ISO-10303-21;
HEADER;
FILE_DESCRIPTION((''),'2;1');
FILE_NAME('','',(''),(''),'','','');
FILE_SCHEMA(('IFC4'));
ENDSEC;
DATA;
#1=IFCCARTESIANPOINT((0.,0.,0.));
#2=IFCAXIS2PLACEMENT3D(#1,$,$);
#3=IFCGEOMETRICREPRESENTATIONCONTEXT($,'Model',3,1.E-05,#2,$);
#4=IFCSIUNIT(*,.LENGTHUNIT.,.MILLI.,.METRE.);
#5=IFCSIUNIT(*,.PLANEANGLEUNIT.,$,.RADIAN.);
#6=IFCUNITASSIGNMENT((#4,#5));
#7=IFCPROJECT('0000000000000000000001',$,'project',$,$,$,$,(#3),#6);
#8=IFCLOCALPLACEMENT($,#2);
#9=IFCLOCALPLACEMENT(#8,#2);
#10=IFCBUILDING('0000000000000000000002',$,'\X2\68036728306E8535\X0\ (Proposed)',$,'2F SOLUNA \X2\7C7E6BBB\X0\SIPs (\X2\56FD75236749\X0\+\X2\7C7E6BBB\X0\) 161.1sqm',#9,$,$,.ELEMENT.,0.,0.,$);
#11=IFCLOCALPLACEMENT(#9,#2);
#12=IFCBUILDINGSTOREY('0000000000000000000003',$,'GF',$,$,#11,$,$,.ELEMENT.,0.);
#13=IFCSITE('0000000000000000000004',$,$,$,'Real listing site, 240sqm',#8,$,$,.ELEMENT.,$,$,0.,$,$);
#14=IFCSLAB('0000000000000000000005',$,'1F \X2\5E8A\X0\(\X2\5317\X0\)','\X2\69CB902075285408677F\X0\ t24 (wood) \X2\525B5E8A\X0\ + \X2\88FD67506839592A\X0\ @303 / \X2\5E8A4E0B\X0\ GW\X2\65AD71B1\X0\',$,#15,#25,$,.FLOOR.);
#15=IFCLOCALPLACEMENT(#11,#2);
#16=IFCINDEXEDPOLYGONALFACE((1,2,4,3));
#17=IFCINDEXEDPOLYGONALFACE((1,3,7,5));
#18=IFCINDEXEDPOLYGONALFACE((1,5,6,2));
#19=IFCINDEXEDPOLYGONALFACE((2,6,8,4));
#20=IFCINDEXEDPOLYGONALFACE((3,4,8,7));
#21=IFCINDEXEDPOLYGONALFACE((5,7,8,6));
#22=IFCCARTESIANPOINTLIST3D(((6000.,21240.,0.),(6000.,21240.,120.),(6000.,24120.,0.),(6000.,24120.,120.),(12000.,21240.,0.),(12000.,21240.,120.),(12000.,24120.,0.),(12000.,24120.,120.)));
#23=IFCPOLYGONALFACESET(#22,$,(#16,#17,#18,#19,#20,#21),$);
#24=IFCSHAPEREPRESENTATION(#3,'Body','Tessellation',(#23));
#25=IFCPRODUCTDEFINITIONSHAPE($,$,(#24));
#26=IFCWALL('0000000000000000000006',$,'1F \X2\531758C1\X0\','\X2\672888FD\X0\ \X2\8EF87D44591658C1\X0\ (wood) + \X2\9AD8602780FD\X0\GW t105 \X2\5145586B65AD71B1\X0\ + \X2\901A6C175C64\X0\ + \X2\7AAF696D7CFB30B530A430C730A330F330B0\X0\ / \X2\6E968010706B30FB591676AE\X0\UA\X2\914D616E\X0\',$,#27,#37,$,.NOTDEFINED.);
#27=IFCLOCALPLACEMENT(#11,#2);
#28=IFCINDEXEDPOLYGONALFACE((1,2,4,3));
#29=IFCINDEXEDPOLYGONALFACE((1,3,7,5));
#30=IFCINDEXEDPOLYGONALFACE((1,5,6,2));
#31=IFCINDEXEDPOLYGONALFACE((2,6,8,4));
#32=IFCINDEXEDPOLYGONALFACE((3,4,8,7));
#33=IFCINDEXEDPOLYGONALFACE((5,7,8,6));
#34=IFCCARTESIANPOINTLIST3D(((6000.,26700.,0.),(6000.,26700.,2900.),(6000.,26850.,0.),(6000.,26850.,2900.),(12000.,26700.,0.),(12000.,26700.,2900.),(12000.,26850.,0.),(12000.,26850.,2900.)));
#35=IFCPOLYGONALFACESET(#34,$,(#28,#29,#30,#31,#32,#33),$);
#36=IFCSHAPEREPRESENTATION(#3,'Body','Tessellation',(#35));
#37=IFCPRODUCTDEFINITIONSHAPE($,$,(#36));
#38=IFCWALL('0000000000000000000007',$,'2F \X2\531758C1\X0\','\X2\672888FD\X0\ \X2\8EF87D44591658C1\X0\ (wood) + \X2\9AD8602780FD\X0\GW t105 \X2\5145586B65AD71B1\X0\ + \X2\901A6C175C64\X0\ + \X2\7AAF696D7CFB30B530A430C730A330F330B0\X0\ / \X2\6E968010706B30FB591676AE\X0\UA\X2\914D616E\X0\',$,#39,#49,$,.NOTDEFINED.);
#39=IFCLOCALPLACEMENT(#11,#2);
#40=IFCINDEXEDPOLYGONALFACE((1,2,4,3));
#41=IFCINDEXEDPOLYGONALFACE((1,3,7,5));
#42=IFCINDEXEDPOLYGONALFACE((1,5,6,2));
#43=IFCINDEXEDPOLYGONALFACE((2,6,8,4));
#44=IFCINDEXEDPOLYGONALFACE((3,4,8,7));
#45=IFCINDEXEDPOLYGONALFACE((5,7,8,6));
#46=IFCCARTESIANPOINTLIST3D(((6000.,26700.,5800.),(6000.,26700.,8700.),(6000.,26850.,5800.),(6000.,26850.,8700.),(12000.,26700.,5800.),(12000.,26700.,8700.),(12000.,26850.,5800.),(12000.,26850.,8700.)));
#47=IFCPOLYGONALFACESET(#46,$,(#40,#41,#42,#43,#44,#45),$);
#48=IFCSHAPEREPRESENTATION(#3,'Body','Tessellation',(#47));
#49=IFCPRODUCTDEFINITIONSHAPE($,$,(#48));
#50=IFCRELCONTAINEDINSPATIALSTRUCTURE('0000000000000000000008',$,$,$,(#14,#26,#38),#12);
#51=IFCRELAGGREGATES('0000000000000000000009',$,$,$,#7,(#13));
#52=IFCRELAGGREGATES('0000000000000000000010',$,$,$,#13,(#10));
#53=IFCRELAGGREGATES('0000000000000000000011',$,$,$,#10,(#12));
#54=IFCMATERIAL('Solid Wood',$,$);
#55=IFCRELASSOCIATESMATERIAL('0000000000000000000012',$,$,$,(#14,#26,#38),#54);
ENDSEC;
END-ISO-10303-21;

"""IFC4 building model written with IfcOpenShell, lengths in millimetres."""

from ifc_helpers import new_model, si_unit, frame, frame_2d, origin, place, context, project, spatial, rectangle, extrude, material, element, save


model = new_model("IFC4")

# Units and contexts
model_context = context("Model", 3, precision=1e-05, world=origin())
ifc_project = project(units=[si_unit("LENGTHUNIT", "METRE", prefix="MILLI"), si_unit("PLANEANGLEUNIT", "RADIAN")], contexts=[model_context])

# Site, building, storey
site_placement = place(None, origin())
site = spatial("IfcSite", under=ifc_project, at=site_placement, ObjectType="Real listing site, 240sqm", CompositionType="ELEMENT", RefElevation=0.0)
building_placement = place(site_placement, origin())
building = spatial("IfcBuilding", under=site, at=building_placement, Name="栃木の蔵 (Proposed)", ObjectType="2F SOLUNA 籾殻SIPs (国産杉+籾殻) 161.1sqm", CompositionType="ELEMENT", ElevationOfRefHeight=0.0, ElevationOfTerrain=0.0)
storey_placement = place(building_placement, origin())
storey = spatial("IfcBuildingStorey", under=building, at=storey_placement, Name="GF", CompositionType="ELEMENT", Elevation=0.0)

# Slab
ifc_material_1 = material(Name="Solid Wood")
slab_1_placement = place(storey_placement, frame((3000.0, 10620.0, 0.0)))
element("IfcSlab", 1, at=slab_1_placement, inside=storey, material=ifc_material_1, Name="1F 床(北)", Description="構造用合板 t24 (wood) 剛床 + 製材根太 @303 / 床下 GW断熱", PredefinedType="FLOOR", context=model_context, shape_type="SweptSolid", body=[
    extrude(rectangle(XDim=6000.0, YDim=2880.0, at=frame_2d((3000.0, 1440.0))), frame((3000.0, 10620.0, 0.0)), (0.0, 0.0, 1.0), 120.0),
])

# Wall
wall_1_placement = place(storey_placement, frame((3000.0, 13350.0, 0.0)))
element("IfcWall", 2, at=wall_1_placement, inside=storey, material=ifc_material_1, Name="1F 北壁", Description="木製 軸組外壁 (wood) + 高性能GW t105 充填断熱 + 通気層 + 窯業系サイディング / 準耐火・外皮UA配慮", PredefinedType="NOTDEFINED", context=model_context, shape_type="SweptSolid", body=[
    extrude(rectangle(XDim=6000.0, YDim=150.0, at=frame_2d((3000.0, 75.0))), frame((3000.0, 13350.0, 0.0)), (0.0, 0.0, 1.0), 2900.0),
])

# Wall
wall_2_placement = place(storey_placement, frame((3000.0, 13350.0, 2900.0)))
element("IfcWall", 3, at=wall_2_placement, inside=storey, material=ifc_material_1, Name="2F 北壁", Description="木製 軸組外壁 (wood) + 高性能GW t105 充填断熱 + 通気層 + 窯業系サイディング / 準耐火・外皮UA配慮", PredefinedType="NOTDEFINED", context=model_context, shape_type="SweptSolid", body=[
    extrude(rectangle(XDim=6000.0, YDim=150.0, at=frame_2d((3000.0, 75.0))), frame((3000.0, 13350.0, 2900.0)), (0.0, 0.0, 1.0), 2900.0),
])

save(model, "model.ifc")
